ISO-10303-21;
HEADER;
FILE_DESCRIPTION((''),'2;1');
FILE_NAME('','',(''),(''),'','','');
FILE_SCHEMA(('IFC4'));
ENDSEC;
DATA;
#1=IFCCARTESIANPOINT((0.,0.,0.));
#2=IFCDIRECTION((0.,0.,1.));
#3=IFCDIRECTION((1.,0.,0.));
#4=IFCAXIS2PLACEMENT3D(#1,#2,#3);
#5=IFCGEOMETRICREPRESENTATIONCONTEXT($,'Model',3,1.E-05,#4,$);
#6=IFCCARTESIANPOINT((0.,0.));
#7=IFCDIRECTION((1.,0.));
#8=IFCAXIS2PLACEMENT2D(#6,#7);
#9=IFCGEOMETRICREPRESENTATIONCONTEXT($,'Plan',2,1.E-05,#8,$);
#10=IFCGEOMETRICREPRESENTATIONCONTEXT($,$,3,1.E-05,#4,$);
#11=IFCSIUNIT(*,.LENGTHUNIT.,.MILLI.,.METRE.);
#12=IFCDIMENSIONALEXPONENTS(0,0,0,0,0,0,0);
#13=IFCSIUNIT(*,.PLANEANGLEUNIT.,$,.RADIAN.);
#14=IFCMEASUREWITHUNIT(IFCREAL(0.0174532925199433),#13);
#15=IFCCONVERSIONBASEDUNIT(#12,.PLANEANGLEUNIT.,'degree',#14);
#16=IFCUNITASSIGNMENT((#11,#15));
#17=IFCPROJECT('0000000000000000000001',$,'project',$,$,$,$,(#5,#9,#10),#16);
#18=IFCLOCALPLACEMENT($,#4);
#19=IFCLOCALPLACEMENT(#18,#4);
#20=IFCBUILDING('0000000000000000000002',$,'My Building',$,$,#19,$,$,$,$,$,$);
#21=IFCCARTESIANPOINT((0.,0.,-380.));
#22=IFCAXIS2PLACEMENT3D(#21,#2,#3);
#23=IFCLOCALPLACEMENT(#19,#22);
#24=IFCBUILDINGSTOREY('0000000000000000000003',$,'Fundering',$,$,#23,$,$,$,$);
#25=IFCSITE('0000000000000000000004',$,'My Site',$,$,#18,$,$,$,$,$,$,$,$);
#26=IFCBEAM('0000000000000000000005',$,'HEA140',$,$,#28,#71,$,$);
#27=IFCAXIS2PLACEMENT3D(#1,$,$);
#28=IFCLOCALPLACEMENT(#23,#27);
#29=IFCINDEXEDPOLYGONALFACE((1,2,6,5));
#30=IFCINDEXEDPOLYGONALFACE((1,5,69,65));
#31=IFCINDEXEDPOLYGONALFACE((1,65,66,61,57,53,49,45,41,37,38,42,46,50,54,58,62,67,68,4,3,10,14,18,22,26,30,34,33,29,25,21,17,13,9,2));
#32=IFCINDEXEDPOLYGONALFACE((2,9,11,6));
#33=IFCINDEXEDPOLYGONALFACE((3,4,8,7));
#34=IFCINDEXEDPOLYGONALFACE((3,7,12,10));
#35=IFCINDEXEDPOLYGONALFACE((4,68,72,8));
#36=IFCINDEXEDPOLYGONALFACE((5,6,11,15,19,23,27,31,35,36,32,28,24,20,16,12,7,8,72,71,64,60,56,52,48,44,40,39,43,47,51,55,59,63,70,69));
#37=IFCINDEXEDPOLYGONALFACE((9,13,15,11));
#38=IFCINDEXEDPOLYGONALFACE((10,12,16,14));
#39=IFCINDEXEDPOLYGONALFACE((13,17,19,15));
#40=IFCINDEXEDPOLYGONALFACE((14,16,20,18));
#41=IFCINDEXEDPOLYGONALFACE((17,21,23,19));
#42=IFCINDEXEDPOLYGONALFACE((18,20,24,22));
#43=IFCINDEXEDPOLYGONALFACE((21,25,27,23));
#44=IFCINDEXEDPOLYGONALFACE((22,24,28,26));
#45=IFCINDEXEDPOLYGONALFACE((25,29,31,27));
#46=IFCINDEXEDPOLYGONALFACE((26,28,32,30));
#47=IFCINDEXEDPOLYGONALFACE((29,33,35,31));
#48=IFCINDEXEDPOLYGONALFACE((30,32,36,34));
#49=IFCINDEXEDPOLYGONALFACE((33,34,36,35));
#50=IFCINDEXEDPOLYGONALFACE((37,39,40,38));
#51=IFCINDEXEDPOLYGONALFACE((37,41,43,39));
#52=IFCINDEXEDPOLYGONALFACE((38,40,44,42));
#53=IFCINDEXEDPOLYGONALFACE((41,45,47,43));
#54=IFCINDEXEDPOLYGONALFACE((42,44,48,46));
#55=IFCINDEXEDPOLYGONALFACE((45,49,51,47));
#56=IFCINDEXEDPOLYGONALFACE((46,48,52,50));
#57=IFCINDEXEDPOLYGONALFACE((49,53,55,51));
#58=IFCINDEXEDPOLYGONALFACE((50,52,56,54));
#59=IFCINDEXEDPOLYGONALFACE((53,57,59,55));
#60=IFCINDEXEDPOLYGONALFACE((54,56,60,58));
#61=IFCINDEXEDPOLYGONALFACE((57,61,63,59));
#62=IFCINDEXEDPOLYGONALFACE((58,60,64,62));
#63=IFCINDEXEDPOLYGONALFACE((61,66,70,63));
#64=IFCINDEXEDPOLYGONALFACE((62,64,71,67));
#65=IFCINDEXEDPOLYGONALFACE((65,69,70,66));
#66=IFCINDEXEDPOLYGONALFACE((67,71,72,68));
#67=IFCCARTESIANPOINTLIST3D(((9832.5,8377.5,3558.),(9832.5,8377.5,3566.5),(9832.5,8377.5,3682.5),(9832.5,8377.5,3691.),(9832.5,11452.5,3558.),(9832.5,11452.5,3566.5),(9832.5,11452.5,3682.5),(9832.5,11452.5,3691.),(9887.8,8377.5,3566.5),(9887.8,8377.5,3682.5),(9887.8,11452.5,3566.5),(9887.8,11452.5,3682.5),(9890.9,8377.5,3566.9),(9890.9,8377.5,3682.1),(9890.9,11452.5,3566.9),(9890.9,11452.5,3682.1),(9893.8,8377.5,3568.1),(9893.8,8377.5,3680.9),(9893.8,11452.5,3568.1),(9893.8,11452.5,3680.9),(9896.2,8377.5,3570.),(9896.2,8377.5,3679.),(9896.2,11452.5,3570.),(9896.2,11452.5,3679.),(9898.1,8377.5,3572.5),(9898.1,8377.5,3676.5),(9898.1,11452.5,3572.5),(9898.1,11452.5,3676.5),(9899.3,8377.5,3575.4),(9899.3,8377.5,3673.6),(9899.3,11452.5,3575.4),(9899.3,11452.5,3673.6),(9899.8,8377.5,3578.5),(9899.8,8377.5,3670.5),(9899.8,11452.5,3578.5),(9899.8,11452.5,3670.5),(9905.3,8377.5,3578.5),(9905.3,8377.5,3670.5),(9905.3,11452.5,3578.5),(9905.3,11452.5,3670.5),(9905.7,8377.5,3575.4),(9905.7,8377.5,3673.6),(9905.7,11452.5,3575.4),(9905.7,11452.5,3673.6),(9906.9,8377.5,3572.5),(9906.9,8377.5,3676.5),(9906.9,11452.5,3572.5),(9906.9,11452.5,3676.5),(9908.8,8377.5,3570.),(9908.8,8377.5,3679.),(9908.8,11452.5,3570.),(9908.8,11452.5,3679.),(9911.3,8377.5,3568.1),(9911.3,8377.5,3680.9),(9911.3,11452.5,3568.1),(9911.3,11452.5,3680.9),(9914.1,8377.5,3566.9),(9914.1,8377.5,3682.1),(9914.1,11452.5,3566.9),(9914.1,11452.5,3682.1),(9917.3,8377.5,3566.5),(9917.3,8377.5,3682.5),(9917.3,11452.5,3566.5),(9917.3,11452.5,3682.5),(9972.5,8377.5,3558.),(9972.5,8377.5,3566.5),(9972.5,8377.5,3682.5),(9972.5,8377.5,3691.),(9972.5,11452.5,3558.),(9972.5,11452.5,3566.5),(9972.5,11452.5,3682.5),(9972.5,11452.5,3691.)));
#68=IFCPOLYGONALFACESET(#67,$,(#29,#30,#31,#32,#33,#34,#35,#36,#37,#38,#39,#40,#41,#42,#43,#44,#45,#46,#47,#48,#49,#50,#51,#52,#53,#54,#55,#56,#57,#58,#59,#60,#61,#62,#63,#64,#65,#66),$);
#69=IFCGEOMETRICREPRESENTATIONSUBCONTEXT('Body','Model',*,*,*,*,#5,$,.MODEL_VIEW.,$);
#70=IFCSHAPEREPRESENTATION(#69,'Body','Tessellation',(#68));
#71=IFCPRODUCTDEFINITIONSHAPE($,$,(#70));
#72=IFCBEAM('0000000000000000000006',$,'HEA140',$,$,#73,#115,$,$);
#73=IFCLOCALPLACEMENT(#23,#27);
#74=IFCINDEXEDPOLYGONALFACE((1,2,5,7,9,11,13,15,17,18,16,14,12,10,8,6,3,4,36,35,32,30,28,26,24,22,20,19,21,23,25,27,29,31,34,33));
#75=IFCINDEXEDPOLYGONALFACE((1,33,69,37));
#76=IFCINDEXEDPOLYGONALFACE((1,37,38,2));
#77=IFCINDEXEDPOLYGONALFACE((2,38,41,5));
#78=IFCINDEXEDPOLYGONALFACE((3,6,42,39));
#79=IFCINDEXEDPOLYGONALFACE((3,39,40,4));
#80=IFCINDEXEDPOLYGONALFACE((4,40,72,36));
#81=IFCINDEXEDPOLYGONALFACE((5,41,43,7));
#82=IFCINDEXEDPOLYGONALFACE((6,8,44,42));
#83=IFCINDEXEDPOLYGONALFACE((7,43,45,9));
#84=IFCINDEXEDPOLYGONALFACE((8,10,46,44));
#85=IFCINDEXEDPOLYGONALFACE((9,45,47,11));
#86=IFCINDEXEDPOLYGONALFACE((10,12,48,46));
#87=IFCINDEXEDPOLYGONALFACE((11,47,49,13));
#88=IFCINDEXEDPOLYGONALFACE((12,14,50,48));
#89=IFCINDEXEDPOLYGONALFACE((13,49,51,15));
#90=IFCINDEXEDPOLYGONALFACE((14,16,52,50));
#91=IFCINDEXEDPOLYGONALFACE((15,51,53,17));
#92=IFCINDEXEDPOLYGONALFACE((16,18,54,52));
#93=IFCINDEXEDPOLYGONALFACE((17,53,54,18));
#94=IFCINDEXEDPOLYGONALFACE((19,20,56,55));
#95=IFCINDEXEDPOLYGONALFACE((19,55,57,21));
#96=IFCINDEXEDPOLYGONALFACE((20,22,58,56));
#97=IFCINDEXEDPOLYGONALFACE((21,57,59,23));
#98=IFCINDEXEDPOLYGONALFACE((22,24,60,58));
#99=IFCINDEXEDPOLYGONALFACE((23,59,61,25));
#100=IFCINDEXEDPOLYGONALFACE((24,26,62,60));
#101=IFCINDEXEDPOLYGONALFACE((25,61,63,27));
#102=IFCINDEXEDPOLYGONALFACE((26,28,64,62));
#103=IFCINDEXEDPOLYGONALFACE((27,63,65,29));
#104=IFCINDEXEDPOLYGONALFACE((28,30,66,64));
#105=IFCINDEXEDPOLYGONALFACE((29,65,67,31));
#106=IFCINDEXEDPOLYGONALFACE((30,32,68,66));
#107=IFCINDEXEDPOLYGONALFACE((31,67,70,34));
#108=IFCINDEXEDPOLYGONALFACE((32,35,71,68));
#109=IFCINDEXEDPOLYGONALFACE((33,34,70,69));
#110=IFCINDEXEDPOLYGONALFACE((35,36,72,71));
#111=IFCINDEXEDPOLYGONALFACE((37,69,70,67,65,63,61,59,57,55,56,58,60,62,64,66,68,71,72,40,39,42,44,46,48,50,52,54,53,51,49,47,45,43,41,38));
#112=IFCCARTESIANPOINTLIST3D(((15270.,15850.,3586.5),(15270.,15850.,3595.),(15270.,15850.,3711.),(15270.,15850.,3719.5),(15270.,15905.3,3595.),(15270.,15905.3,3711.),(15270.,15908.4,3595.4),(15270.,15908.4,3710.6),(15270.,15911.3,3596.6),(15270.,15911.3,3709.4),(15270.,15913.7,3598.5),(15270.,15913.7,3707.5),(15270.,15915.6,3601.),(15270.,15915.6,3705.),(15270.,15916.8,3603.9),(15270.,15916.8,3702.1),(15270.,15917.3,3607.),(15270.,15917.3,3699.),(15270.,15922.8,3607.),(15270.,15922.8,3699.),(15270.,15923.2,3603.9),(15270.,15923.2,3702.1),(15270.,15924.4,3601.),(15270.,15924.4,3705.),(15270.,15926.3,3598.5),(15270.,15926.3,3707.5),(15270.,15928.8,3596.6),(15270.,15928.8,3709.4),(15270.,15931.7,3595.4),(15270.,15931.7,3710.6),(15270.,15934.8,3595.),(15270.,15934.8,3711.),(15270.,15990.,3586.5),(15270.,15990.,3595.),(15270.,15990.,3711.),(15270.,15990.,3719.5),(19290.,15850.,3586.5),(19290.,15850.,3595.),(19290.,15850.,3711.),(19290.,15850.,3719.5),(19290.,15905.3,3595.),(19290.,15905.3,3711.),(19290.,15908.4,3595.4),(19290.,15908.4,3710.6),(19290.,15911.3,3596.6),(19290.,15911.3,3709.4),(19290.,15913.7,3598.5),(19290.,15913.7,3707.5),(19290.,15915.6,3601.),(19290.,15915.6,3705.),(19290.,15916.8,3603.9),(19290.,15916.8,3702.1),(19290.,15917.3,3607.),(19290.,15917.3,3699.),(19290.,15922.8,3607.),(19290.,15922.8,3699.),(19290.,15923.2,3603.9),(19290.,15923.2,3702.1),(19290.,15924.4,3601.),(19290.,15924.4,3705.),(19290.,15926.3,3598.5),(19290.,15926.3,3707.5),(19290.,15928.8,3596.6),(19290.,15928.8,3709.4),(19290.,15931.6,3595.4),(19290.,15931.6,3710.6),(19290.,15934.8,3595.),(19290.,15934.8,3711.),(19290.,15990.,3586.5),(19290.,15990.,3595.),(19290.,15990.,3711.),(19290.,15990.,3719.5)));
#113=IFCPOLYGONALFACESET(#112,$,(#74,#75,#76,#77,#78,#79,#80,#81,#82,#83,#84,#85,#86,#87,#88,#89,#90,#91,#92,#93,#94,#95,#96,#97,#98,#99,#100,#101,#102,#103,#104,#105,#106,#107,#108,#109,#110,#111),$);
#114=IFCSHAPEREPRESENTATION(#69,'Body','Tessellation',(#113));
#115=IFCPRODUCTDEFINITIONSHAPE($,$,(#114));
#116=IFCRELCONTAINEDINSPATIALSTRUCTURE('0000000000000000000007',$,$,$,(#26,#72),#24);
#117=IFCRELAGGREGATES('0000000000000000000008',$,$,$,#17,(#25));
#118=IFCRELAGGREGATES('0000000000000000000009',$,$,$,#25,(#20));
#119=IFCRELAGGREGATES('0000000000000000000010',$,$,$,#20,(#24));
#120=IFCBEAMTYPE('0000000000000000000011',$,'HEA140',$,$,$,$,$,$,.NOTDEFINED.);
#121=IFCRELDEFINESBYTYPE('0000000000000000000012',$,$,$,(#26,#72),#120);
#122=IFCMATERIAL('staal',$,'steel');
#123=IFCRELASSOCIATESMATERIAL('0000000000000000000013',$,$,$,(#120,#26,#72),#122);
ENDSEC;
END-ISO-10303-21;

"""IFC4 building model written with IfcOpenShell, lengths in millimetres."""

from ifc_helpers import new_model, entity, si_unit, converted_unit, frame, origin_with_axes, origin_2d_with_axis, place, context, subcontext, project, spatial, i_section, extrude, material, material_profile, profile_set, profile_usage, type_object, element, save


model = new_model("IFC4")

# Units and contexts
model_context = context("Model", 3, precision=1e-05, world=origin_with_axes())
plan_context = context("Plan", 2, precision=1e-05, world=origin_2d_with_axis())
context_of_model = context(None, 3, precision=1e-05, world=origin_with_axes())
body_context = subcontext(model_context, "Body", "Model", "MODEL_VIEW")
ifc_project = project(units=[si_unit("LENGTHUNIT", "METRE", prefix="MILLI"), converted_unit("PLANEANGLEUNIT", "degree", entity("IfcReal", 0.0174532925199433), si_unit("PLANEANGLEUNIT", "RADIAN"), dimensions=[0, 0, 0, 0, 0, 0, 0])], contexts=[model_context, plan_context, context_of_model])

# Site, building, storey
site_placement = place(None, origin_with_axes())
site = spatial("IfcSite", under=ifc_project, at=site_placement, Name="My Site")
building_placement = place(site_placement, origin_with_axes())
building = spatial("IfcBuilding", under=site, at=building_placement, Name="My Building")
storey_placement = place(building_placement, frame((0.0, 0.0, -380.0), z_axis=(0.0, 0.0, 1.0), x_axis=(1.0, 0.0, 0.0)))
storey = spatial("IfcBuildingStorey", under=building, at=storey_placement, Name="Fundering")

# Beams
ifc_material_1 = material(Name="staal", Category="steel")
ifc_material_profile_1 = material_profile(ifc_material_1, i_section(OverallWidth=140.0, OverallDepth=133.0, WebThickness=5.5, FlangeThickness=8.5, FilletRadius=12.0))
ifc_profile_set_1 = profile_set([ifc_material_profile_1], Name="HEA140")
beam_type_1 = type_object("IfcBeamType", Name="HEA140", PredefinedType="NOTDEFINED", material=ifc_profile_set_1)
ifc_profile_usage_1 = profile_usage(ifc_profile_set_1)
beam_1_placement = place(storey_placement, frame((9902.5, 8377.5, 3624.5), z_axis=(0.0, 1.0, 0.0), x_axis=(-1.0, 0.0, 0.0)))
element("IfcBeam", 1, at=beam_1_placement, inside=storey, type_object=beam_type_1, material=ifc_profile_usage_1, Name="HEA140", context=body_context, shape_type="SweptSolid", body=[
    extrude(i_section(OverallWidth=140.0, OverallDepth=133.0, WebThickness=5.5, FlangeThickness=8.5, FilletRadius=12.0), origin_with_axes(), (0.0, 0.0, 1.0), 3075.0),
])
ifc_profile_usage_2 = profile_usage(ifc_profile_set_1)
beam_2_placement = place(storey_placement, frame((19290.0, 15920.0, 3653.0), z_axis=(-1.0, 0.0, 0.0), x_axis=(0.0, -1.0, 0.0)))
element("IfcBeam", 2, at=beam_2_placement, inside=storey, type_object=beam_type_1, material=ifc_profile_usage_2, Name="HEA140", context=body_context, shape_type="SweptSolid", body=[
    extrude(i_section(OverallWidth=140.0, OverallDepth=133.0, WebThickness=5.5, FlangeThickness=8.5, FilletRadius=12.0), origin_with_axes(), (0.0, 0.0, 1.0), 4020.0),
])

save(model, "model.ifc")
